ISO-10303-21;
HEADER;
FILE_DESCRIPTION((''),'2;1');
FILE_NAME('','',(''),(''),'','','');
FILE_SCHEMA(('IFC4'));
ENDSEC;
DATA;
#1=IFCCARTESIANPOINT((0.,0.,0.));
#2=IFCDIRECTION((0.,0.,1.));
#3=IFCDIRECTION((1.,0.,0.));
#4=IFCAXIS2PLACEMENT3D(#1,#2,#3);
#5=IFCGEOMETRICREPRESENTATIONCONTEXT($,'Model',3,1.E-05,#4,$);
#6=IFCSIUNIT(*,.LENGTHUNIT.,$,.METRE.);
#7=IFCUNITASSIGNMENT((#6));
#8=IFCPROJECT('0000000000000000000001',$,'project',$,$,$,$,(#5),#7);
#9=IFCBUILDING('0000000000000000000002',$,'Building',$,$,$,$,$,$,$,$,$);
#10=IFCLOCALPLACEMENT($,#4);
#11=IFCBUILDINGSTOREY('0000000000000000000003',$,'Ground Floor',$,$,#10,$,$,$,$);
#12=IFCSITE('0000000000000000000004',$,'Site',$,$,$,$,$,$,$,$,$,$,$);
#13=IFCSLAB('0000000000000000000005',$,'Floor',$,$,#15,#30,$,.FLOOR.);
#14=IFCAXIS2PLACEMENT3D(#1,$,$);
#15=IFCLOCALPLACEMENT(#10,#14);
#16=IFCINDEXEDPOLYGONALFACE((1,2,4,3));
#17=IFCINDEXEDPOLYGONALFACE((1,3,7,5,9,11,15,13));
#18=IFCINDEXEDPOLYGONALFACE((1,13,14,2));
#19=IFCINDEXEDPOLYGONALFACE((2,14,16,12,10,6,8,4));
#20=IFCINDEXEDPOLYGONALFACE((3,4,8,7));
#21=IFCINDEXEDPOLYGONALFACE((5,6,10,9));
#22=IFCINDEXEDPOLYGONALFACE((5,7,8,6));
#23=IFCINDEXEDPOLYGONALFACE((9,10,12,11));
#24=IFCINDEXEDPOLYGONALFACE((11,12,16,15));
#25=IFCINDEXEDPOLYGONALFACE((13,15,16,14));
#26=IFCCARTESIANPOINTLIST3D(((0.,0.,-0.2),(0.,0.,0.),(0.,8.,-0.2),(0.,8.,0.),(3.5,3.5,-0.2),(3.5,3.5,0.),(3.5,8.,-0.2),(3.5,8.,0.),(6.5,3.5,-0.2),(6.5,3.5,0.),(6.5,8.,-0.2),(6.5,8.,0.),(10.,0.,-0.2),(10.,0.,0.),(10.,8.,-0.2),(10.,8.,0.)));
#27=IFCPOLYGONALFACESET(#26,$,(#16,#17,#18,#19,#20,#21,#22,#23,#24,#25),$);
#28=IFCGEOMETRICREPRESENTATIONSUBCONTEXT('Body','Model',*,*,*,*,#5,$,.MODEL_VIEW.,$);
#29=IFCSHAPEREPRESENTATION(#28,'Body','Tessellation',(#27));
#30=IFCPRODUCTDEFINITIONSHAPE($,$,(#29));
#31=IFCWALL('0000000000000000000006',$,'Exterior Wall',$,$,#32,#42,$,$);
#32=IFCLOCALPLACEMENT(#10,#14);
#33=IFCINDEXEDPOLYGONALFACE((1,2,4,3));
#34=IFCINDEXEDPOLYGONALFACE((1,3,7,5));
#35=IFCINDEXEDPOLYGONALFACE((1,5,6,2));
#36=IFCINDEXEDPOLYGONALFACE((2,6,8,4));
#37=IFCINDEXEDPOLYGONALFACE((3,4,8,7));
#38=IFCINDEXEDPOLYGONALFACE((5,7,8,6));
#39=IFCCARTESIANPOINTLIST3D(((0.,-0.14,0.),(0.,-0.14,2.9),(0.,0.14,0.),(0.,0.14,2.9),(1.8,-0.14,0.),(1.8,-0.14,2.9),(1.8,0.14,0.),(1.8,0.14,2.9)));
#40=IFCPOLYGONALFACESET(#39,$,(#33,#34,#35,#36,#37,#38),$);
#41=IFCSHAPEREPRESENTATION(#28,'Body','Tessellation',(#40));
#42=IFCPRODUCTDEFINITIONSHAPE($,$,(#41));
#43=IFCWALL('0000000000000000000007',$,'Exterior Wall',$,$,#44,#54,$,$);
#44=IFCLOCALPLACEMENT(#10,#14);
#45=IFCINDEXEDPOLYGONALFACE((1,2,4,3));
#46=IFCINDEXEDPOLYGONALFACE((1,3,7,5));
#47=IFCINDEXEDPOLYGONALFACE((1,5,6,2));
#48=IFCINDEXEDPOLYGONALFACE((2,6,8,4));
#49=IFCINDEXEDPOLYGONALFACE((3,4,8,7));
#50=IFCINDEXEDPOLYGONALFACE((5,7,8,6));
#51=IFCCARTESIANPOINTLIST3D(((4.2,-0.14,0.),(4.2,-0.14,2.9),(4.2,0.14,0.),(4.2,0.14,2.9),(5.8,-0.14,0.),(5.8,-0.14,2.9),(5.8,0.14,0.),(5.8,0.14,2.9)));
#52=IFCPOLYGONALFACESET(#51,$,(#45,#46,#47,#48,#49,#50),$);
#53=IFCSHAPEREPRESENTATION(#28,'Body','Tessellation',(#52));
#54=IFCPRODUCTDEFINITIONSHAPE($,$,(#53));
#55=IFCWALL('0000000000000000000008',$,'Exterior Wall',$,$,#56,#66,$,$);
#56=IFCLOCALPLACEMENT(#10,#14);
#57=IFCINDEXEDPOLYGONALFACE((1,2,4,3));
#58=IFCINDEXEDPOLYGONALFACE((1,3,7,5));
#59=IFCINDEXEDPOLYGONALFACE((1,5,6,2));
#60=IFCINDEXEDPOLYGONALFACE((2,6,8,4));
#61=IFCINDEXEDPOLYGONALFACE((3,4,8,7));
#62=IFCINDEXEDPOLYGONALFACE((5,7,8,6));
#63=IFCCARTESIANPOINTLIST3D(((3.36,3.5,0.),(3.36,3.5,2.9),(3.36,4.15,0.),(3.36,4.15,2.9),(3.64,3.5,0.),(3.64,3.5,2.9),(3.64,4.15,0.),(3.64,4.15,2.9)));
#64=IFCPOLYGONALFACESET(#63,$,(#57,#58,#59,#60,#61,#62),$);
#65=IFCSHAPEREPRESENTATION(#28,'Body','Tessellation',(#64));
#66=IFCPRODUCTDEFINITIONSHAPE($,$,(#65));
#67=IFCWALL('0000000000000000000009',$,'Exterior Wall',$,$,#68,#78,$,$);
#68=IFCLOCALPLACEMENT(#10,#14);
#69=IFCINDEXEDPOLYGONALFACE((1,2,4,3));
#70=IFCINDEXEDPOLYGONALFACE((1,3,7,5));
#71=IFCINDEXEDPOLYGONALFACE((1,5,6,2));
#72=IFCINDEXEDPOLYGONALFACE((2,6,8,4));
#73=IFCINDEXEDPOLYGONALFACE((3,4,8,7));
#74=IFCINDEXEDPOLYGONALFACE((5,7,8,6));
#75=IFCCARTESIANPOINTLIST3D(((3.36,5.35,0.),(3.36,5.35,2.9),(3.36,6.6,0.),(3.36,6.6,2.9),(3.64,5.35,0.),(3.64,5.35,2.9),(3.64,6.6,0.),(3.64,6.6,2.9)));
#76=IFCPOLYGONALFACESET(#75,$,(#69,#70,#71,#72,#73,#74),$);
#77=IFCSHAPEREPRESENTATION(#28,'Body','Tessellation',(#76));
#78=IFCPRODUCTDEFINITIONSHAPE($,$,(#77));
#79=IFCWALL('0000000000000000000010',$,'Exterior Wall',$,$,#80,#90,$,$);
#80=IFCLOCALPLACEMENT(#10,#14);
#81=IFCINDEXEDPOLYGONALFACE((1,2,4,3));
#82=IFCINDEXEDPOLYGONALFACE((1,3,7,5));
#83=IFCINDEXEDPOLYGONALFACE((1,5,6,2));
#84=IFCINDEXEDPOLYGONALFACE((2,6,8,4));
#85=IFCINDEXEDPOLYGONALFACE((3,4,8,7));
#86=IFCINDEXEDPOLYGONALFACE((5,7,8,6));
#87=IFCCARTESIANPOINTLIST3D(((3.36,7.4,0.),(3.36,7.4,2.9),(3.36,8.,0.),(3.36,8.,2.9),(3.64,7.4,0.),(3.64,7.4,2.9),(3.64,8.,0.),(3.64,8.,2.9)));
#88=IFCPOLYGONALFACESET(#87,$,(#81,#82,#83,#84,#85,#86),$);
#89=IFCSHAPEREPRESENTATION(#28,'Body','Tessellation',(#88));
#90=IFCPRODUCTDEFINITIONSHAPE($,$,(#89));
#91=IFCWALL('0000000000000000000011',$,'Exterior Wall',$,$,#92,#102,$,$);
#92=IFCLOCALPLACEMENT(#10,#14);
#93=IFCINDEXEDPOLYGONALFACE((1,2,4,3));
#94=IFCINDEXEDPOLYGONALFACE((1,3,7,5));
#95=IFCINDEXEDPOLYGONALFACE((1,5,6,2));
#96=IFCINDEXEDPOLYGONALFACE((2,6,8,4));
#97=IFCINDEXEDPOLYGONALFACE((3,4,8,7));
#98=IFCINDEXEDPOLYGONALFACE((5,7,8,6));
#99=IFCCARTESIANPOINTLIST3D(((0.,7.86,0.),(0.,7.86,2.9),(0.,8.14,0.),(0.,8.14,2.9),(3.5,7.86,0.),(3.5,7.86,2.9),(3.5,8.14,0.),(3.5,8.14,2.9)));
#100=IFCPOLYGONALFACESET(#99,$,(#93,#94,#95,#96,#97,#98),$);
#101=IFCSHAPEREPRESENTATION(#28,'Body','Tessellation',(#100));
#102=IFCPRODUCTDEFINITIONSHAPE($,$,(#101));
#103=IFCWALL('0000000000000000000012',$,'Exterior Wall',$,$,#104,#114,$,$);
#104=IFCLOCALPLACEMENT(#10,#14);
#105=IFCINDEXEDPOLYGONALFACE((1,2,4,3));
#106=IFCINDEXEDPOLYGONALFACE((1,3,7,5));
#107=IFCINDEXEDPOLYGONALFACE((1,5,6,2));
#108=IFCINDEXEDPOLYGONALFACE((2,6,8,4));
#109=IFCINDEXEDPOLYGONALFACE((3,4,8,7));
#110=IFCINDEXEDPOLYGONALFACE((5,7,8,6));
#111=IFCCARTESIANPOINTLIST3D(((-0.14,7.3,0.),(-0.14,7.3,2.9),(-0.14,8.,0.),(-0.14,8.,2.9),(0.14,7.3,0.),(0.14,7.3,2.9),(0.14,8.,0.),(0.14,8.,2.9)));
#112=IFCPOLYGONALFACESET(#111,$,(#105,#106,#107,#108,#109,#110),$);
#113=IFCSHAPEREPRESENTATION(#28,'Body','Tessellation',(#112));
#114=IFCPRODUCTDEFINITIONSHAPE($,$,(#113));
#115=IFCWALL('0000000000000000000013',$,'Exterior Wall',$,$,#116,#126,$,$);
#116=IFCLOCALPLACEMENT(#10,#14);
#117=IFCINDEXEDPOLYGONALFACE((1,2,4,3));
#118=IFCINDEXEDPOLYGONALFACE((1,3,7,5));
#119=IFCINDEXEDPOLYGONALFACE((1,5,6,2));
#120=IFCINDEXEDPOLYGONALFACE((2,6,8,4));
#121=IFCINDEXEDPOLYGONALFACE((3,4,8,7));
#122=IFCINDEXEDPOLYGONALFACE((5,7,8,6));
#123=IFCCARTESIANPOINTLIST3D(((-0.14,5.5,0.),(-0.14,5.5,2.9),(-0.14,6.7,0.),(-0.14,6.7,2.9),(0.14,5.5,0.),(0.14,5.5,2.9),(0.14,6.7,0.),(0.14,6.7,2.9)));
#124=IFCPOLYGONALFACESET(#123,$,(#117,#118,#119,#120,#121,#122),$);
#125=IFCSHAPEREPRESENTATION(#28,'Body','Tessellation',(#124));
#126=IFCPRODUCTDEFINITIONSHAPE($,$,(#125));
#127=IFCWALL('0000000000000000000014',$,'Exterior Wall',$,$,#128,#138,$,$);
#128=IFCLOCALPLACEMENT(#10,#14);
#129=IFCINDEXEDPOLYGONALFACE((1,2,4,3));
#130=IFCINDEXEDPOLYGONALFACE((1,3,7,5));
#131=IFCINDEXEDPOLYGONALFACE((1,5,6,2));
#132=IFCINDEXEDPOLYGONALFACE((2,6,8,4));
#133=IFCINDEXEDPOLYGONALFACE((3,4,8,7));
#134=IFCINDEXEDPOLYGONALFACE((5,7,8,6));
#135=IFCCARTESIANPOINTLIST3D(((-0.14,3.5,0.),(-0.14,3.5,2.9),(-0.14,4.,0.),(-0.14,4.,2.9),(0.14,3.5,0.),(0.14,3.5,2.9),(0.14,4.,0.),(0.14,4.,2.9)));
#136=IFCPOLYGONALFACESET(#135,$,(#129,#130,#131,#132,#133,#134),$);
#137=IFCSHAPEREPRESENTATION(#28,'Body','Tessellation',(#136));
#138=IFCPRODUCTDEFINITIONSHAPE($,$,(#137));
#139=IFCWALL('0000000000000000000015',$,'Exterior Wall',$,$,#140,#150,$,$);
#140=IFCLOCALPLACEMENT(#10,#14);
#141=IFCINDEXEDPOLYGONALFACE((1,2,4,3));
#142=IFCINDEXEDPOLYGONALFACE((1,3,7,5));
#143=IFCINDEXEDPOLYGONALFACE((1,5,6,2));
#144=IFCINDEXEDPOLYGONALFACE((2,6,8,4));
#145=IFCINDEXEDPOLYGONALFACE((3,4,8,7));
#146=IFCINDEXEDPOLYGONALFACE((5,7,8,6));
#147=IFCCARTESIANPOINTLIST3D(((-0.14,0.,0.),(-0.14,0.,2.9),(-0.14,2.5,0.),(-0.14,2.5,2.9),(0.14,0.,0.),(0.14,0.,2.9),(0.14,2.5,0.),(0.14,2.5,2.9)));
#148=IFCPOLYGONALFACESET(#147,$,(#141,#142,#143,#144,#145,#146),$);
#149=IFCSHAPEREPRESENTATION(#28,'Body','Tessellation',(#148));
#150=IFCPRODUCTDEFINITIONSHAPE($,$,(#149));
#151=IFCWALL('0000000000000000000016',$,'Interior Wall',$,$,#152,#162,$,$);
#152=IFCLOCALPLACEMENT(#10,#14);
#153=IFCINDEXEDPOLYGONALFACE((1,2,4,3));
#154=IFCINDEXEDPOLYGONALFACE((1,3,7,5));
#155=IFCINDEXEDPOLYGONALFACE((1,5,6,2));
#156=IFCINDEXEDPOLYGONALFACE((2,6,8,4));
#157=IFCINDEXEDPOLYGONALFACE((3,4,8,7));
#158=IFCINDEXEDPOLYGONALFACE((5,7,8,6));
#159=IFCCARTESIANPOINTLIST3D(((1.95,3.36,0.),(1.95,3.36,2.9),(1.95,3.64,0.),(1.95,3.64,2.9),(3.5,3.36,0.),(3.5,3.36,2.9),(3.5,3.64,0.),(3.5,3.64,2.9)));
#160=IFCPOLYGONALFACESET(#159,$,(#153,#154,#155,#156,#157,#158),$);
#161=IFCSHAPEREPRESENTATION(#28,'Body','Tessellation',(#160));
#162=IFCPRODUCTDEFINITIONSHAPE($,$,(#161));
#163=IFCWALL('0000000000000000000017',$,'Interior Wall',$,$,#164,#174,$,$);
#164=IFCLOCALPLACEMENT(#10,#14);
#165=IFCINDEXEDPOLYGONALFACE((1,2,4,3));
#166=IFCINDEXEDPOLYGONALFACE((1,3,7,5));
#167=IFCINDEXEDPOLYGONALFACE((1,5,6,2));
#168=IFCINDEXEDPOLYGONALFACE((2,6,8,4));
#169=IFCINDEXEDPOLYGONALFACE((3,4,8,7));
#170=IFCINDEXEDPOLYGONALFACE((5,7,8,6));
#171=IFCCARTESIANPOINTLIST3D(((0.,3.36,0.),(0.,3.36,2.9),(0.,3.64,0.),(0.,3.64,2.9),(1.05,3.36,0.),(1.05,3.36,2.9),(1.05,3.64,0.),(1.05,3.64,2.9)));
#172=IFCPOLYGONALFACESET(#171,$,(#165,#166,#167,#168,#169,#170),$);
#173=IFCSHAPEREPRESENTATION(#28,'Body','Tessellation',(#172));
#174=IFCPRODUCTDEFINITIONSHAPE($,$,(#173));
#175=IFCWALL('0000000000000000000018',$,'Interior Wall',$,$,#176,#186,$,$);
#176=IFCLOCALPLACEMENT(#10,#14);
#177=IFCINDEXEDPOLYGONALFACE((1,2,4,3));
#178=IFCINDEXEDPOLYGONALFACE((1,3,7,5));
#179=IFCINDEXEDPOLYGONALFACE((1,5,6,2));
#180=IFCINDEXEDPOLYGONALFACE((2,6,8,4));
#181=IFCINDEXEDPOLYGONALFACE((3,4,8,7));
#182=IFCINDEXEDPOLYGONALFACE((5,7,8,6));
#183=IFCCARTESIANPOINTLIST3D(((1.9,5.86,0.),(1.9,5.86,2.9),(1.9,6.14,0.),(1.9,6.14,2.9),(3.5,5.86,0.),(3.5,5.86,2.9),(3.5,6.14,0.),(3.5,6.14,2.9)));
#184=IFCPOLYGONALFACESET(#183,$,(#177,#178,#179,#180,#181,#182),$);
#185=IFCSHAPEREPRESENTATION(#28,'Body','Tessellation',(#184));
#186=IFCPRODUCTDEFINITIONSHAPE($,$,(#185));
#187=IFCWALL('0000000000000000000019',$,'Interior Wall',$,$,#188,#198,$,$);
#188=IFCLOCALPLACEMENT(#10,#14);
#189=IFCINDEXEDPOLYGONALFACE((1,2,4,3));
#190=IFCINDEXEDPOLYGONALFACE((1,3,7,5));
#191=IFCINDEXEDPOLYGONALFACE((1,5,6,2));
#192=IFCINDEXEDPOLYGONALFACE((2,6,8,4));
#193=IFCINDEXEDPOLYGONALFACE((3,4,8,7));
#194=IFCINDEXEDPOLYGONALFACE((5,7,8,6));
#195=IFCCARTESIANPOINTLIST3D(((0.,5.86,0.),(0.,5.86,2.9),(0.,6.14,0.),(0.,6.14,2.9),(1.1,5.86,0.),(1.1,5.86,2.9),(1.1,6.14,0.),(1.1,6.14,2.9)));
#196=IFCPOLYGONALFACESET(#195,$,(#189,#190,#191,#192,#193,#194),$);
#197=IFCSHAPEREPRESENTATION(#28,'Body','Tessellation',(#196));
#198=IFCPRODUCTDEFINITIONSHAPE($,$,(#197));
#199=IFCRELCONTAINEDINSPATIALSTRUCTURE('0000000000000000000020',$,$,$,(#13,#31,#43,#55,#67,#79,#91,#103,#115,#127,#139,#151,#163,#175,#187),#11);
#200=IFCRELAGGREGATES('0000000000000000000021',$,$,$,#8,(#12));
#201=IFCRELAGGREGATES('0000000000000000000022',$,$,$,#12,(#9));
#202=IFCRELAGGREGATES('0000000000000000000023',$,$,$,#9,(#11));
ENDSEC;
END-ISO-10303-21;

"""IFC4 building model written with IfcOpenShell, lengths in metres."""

from ifc_helpers import new_model, si_unit, frame, origin_with_axes, place, context, subcontext, project, spatial, indexed_curve, outline, extrude, element, save


model = new_model("IFC4")

# Units and contexts
model_context = context("Model", 3, precision=1e-05, world=origin_with_axes())
body_context = subcontext(model_context, "Body", "Model", "MODEL_VIEW")
ifc_project = project(units=[si_unit("LENGTHUNIT", "METRE")], contexts=[model_context])

# Site, building, storey
site = spatial("IfcSite", under=ifc_project, Name="Site")
building = spatial("IfcBuilding", under=site, Name="Building")
storey_placement = place(None, origin_with_axes())
storey = spatial("IfcBuildingStorey", under=building, at=storey_placement, Name="Ground Floor")

# Slab
slab_placement = place(storey_placement, frame((0.0, 0.0, -0.2), z_axis=(0.0, 0.0, 1.0), x_axis=(1.0, 0.0, 0.0)))
element("IfcSlab", 1, at=slab_placement, inside=storey, Name="Floor", PredefinedType="FLOOR", context=body_context, shape_type="SweptSolid", body=[
    extrude(outline(indexed_curve([(0.0, 0.0), (10.0, 0.0), (10.0, 8.0), (6.5, 8.0), (6.5, 3.5), (3.5, 3.5), (3.5, 8.0), (0.0, 8.0)])), None, (0.0, 0.0, 1.0), 0.2),
])

# Walls
wall_1_placement = place(storey_placement, origin_with_axes())
element("IfcWall", 2, at=wall_1_placement, inside=storey, Name="Exterior Wall", context=body_context, shape_type="SweptSolid", body=[
    extrude(outline(indexed_curve([(0.0, 0.0), (0.0, 0.28), (1.8, 0.28), (1.8, 0.0), (0.0, 0.0)], self_intersect=False)), frame((0.0, -0.14, 0.0), z_axis=(0.0, 0.0, 1.0), x_axis=(1.0, 0.0, 0.0)), (0.0, 0.0, 1.0), 2.9),
])
wall_2_placement = place(storey_placement, frame((4.2, 0.0, 0.0), z_axis=(0.0, 0.0, 1.0), x_axis=(1.0, 0.0, 0.0)))
element("IfcWall", 3, at=wall_2_placement, inside=storey, Name="Exterior Wall", context=body_context, shape_type="SweptSolid", body=[
    extrude(outline(indexed_curve([(0.0, 0.0), (0.0, 0.28), (1.6, 0.28), (1.6, 0.0), (0.0, 0.0)], self_intersect=False)), frame((0.0, -0.14, 0.0), z_axis=(0.0, 0.0, 1.0), x_axis=(1.0, 0.0, 0.0)), (0.0, 0.0, 1.0), 2.9),
])
wall_3_placement = place(storey_placement, frame((3.5, 3.5, 0.0), z_axis=(0.0, 0.0, 1.0), x_axis=(0.0, 1.0, 0.0)))
element("IfcWall", 4, at=wall_3_placement, inside=storey, Name="Exterior Wall", context=body_context, shape_type="SweptSolid", body=[
    extrude(outline(indexed_curve([(0.0, 0.0), (0.0, 0.28), (0.65, 0.28), (0.65, 0.0), (0.0, 0.0)], self_intersect=False)), frame((0.0, -0.14, 0.0), z_axis=(0.0, 0.0, 1.0), x_axis=(1.0, 0.0, 0.0)), (0.0, 0.0, 1.0), 2.9),
])
wall_4_placement = place(storey_placement, frame((3.5, 5.35, 0.0), z_axis=(0.0, 0.0, 1.0), x_axis=(0.0, 1.0, 0.0)))
element("IfcWall", 5, at=wall_4_placement, inside=storey, Name="Exterior Wall", context=body_context, shape_type="SweptSolid", body=[
    extrude(outline(indexed_curve([(0.0, 0.0), (0.0, 0.28), (1.25, 0.28), (1.25, 0.0), (0.0, 0.0)], self_intersect=False)), frame((0.0, -0.14, 0.0), z_axis=(0.0, 0.0, 1.0), x_axis=(1.0, 0.0, 0.0)), (0.0, 0.0, 1.0), 2.9),
])
wall_5_placement = place(storey_placement, frame((3.5, 7.4, 0.0), z_axis=(0.0, 0.0, 1.0), x_axis=(0.0, 1.0, 0.0)))
element("IfcWall", 6, at=wall_5_placement, inside=storey, Name="Exterior Wall", context=body_context, shape_type="SweptSolid", body=[
    extrude(outline(indexed_curve([(0.0, 0.0), (0.0, 0.28), (0.6, 0.28), (0.6, 0.0), (0.0, 0.0)], self_intersect=False)), frame((0.0, -0.14, 0.0), z_axis=(0.0, 0.0, 1.0), x_axis=(1.0, 0.0, 0.0)), (0.0, 0.0, 1.0), 2.9),
])
wall_6_placement = place(storey_placement, frame((3.5, 8.0, 0.0), z_axis=(0.0, 0.0, 1.0), x_axis=(-1.0, 0.0, 0.0)))
element("IfcWall", 7, at=wall_6_placement, inside=storey, Name="Exterior Wall", context=body_context, shape_type="SweptSolid", body=[
    extrude(outline(indexed_curve([(0.0, 0.0), (0.0, 0.28), (3.5, 0.28), (3.5, 0.0), (0.0, 0.0)], self_intersect=False)), frame((0.0, -0.14, 0.0), z_axis=(0.0, 0.0, 1.0), x_axis=(1.0, 0.0, 0.0)), (0.0, 0.0, 1.0), 2.9),
])
wall_7_placement = place(storey_placement, frame((0.0, 8.0, 0.0), z_axis=(0.0, 0.0, 1.0), x_axis=(0.0, -1.0, 0.0)))
element("IfcWall", 8, at=wall_7_placement, inside=storey, Name="Exterior Wall", context=body_context, shape_type="SweptSolid", body=[
    extrude(outline(indexed_curve([(0.0, 0.0), (0.0, 0.28), (0.7, 0.28), (0.7, 0.0), (0.0, 0.0)], self_intersect=False)), frame((0.0, -0.14, 0.0), z_axis=(0.0, 0.0, 1.0), x_axis=(1.0, 0.0, 0.0)), (0.0, 0.0, 1.0), 2.9),
])
wall_8_placement = place(storey_placement, frame((0.0, 6.7, 0.0), z_axis=(0.0, 0.0, 1.0), x_axis=(0.0, -1.0, 0.0)))
element("IfcWall", 9, at=wall_8_placement, inside=storey, Name="Exterior Wall", context=body_context, shape_type="SweptSolid", body=[
    extrude(outline(indexed_curve([(0.0, 0.0), (0.0, 0.28), (1.2, 0.28), (1.2, 0.0), (0.0, 0.0)], self_intersect=False)), frame((0.0, -0.14, 0.0), z_axis=(0.0, 0.0, 1.0), x_axis=(1.0, 0.0, 0.0)), (0.0, 0.0, 1.0), 2.9),
])
wall_9_placement = place(storey_placement, frame((0.0, 4.0, 0.0), z_axis=(0.0, 0.0, 1.0), x_axis=(0.0, -1.0, 0.0)))
element("IfcWall", 10, at=wall_9_placement, inside=storey, Name="Exterior Wall", context=body_context, shape_type="SweptSolid", body=[
    extrude(outline(indexed_curve([(0.0, 0.0), (0.0, 0.28), (0.5, 0.28), (0.5, 0.0), (0.0, 0.0)], self_intersect=False)), frame((0.0, -0.14, 0.0), z_axis=(0.0, 0.0, 1.0), x_axis=(1.0, 0.0, 0.0)), (0.0, 0.0, 1.0), 2.9),
])
wall_10_placement = place(storey_placement, frame((0.0, 2.5, 0.0), z_axis=(0.0, 0.0, 1.0), x_axis=(0.0, -1.0, 0.0)))
element("IfcWall", 11, at=wall_10_placement, inside=storey, Name="Exterior Wall", context=body_context, shape_type="SweptSolid", body=[
    extrude(outline(indexed_curve([(0.0, 0.0), (0.0, 0.28), (2.5, 0.28), (2.5, 0.0), (0.0, 0.0)], self_intersect=False)), frame((0.0, -0.14, 0.0), z_axis=(0.0, 0.0, 1.0), x_axis=(1.0, 0.0, 0.0)), (0.0, 0.0, 1.0), 2.9),
])
wall_11_placement = place(storey_placement, frame((3.5, 3.5, 0.0), z_axis=(0.0, 0.0, 1.0), x_axis=(-1.0, 0.0, 0.0)))
element("IfcWall", 12, at=wall_11_placement, inside=storey, Name="Interior Wall", context=body_context, shape_type="SweptSolid", body=[
    extrude(outline(indexed_curve([(0.0, 0.0), (0.0, 0.28), (1.55, 0.28), (1.55, 0.0), (0.0, 0.0)], self_intersect=False)), frame((0.0, -0.14, 0.0), z_axis=(0.0, 0.0, 1.0), x_axis=(1.0, 0.0, 0.0)), (0.0, 0.0, 1.0), 2.9),
])
wall_12_placement = place(storey_placement, frame((1.05, 3.5, 0.0), z_axis=(0.0, 0.0, 1.0), x_axis=(-1.0, 0.0, 0.0)))
element("IfcWall", 13, at=wall_12_placement, inside=storey, Name="Interior Wall", context=body_context, shape_type="SweptSolid", body=[
    extrude(outline(indexed_curve([(0.0, 0.0), (0.0, 0.28), (1.05, 0.28), (1.05, 0.0), (0.0, 0.0)], self_intersect=False)), frame((0.0, -0.14, 0.0), z_axis=(0.0, 0.0, 1.0), x_axis=(1.0, 0.0, 0.0)), (0.0, 0.0, 1.0), 2.9),
])
wall_13_placement = place(storey_placement, frame((3.5, 6.0, 0.0), z_axis=(0.0, 0.0, 1.0), x_axis=(-1.0, 0.0, 0.0)))
element("IfcWall", 14, at=wall_13_placement, inside=storey, Name="Interior Wall", context=body_context, shape_type="SweptSolid", body=[
    extrude(outline(indexed_curve([(0.0, 0.0), (0.0, 0.28), (1.6, 0.28), (1.6, 0.0), (0.0, 0.0)], self_intersect=False)), frame((0.0, -0.14, 0.0), z_axis=(0.0, 0.0, 1.0), x_axis=(1.0, 0.0, 0.0)), (0.0, 0.0, 1.0), 2.9),
])
wall_14_placement = place(storey_placement, frame((1.1, 6.0, 0.0), z_axis=(0.0, 0.0, 1.0), x_axis=(-1.0, 0.0, 0.0)))
element("IfcWall", 15, at=wall_14_placement, inside=storey, Name="Interior Wall", context=body_context, shape_type="SweptSolid", body=[
    extrude(outline(indexed_curve([(0.0, 0.0), (0.0, 0.28), (1.1, 0.28), (1.1, 0.0), (0.0, 0.0)], self_intersect=False)), frame((0.0, -0.14, 0.0), z_axis=(0.0, 0.0, 1.0), x_axis=(1.0, 0.0, 0.0)), (0.0, 0.0, 1.0), 2.9),
])

save(model, "model.ifc")
